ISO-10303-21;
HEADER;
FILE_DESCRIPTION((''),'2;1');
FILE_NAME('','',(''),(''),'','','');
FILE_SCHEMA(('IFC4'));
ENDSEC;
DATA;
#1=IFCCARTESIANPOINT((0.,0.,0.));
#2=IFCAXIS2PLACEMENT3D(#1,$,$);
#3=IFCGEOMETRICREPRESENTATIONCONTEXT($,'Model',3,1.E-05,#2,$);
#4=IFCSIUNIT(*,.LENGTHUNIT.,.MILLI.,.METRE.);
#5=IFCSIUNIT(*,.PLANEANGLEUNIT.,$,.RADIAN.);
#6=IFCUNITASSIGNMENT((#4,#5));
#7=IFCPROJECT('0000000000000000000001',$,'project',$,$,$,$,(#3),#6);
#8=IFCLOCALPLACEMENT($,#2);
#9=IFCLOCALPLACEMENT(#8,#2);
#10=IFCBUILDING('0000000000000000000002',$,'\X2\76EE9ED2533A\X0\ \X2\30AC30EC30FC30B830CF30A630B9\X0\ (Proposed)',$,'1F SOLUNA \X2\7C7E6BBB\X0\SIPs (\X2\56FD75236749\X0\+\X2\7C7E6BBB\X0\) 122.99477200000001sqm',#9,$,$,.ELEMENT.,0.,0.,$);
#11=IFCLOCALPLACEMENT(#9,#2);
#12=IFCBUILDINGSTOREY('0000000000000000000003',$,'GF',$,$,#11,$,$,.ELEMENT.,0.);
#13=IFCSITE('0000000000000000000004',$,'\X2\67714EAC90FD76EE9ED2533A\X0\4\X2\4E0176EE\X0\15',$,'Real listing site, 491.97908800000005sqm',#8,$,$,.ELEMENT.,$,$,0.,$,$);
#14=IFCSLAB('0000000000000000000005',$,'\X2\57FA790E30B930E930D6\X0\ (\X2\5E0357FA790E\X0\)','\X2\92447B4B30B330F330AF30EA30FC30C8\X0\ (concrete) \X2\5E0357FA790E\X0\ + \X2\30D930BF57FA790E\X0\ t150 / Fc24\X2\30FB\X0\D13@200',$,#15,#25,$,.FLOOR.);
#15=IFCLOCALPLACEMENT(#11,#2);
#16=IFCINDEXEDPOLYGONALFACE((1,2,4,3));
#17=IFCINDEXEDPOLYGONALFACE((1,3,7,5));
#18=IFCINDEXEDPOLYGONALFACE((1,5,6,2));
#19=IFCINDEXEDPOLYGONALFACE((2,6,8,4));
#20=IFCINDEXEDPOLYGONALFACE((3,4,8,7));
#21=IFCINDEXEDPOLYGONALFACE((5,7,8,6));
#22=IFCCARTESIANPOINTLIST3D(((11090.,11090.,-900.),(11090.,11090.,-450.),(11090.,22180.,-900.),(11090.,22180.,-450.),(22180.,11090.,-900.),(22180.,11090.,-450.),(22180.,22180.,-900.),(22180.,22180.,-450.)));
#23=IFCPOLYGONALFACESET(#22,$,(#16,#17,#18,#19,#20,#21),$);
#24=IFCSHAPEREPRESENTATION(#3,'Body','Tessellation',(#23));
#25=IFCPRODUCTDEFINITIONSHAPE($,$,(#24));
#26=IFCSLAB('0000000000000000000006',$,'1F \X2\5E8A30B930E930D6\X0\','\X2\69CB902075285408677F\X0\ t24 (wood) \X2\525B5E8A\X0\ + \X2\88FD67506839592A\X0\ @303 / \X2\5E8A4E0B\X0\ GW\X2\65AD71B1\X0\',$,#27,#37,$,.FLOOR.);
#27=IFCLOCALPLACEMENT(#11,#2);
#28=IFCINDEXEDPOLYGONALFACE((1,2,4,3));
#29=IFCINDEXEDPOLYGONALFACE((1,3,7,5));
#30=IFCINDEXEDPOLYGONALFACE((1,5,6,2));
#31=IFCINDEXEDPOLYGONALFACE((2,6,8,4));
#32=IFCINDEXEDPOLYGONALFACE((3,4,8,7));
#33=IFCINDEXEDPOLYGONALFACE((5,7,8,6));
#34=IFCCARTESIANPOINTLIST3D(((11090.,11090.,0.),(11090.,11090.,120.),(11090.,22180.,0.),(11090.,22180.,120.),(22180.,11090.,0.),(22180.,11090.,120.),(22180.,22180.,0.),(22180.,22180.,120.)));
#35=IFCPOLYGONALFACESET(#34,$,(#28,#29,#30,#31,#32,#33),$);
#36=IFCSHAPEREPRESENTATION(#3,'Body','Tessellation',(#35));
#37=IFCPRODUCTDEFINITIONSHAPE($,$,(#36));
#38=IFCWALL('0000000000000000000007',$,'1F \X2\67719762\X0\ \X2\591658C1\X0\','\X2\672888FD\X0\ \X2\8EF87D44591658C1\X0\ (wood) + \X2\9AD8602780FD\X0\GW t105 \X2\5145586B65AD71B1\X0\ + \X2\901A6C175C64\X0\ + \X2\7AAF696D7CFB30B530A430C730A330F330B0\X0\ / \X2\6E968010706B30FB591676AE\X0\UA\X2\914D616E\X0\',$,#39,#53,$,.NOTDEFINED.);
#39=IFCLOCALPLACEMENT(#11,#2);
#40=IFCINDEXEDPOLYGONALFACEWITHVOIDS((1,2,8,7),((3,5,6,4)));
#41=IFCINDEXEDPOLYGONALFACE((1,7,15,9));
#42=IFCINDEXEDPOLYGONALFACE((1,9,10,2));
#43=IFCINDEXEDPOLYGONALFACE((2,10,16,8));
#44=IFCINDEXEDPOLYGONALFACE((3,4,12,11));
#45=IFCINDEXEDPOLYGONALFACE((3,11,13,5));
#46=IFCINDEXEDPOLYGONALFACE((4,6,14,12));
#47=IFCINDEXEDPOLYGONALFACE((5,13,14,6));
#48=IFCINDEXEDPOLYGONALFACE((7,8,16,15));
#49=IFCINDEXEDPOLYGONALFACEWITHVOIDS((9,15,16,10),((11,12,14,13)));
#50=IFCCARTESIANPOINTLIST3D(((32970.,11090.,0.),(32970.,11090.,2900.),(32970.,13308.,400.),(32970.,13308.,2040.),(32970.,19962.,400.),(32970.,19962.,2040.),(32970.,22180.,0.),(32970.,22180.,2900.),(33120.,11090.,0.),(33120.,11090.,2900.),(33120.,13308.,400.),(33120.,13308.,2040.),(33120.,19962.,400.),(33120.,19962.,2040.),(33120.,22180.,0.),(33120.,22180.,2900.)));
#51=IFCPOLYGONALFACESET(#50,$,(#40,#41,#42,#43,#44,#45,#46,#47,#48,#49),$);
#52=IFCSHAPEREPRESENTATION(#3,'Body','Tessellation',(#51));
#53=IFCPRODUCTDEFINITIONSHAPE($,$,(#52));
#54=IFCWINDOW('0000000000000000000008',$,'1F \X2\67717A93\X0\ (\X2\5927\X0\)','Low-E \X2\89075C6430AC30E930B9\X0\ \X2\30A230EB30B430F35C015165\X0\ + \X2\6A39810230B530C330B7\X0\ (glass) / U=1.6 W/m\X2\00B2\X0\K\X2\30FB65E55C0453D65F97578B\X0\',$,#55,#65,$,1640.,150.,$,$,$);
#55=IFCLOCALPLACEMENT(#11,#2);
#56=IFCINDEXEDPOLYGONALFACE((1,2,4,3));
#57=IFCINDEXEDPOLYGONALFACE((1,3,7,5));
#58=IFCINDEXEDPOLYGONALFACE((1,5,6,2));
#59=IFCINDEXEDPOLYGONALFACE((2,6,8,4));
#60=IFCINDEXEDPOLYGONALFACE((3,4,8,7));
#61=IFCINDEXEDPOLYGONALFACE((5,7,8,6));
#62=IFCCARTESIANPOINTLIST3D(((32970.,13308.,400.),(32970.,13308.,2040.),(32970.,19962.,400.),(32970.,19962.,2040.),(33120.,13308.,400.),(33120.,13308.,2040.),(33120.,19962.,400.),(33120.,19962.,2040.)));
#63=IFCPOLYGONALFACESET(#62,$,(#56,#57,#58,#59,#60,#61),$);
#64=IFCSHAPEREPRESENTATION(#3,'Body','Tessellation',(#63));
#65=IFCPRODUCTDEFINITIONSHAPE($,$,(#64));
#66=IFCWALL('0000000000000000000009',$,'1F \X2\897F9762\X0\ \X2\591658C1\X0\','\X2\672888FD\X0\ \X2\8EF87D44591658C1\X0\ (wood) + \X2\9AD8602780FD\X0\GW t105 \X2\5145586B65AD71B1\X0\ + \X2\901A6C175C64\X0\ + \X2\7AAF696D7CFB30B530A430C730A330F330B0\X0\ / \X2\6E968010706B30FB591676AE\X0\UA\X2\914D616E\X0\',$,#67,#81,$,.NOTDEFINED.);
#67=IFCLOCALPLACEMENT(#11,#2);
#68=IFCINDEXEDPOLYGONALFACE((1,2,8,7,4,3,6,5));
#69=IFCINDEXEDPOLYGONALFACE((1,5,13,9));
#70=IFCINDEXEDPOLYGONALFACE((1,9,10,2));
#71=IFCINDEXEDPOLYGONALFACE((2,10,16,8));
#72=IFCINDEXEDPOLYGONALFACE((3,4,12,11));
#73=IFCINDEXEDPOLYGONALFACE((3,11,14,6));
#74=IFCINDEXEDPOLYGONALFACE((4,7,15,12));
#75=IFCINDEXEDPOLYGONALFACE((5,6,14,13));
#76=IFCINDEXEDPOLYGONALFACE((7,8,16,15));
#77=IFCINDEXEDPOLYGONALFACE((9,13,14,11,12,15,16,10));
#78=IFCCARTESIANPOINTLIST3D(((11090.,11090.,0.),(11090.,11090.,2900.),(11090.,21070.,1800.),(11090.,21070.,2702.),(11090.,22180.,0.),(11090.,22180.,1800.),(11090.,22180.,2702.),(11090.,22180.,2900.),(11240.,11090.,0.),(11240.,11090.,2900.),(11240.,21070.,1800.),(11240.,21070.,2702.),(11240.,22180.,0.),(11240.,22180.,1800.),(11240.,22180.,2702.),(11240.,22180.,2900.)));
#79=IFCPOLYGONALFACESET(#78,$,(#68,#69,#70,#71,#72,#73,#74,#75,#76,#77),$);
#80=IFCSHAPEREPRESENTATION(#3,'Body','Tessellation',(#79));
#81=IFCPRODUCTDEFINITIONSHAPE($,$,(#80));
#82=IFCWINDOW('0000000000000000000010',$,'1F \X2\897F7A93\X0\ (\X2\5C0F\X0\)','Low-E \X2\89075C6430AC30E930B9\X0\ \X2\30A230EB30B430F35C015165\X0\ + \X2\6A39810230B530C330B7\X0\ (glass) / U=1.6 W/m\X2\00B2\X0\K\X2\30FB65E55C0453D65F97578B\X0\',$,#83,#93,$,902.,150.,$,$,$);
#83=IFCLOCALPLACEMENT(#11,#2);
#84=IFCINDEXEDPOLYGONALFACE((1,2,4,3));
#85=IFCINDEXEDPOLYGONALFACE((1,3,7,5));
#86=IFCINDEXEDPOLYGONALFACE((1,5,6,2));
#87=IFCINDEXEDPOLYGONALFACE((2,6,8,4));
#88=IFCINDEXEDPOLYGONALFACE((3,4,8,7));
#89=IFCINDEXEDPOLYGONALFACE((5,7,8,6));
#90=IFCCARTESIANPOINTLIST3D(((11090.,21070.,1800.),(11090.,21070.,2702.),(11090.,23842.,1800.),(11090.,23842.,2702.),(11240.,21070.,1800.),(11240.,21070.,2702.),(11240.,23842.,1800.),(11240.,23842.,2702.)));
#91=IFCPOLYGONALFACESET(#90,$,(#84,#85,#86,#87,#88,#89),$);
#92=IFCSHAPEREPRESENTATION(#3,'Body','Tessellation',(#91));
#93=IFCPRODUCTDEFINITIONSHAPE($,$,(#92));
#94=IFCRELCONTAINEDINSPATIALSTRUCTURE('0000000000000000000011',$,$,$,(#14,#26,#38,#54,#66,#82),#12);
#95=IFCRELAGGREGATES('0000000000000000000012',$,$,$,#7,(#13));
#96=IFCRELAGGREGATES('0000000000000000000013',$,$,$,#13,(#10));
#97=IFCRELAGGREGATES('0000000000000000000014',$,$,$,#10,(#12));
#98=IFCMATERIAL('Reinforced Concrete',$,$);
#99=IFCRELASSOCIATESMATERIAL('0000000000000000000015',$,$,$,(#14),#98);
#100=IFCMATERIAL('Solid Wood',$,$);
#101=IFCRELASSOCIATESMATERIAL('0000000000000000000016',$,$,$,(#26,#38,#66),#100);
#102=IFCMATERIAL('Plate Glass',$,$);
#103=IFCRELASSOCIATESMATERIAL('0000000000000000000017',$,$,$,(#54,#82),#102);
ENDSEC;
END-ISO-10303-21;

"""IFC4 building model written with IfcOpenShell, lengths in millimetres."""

from ifc_helpers import new_model, si_unit, frame, frame_2d, origin, place, context, project, spatial, rectangle, extrude, material, element, fill, save


model = new_model("IFC4")

# Units and contexts
model_context = context("Model", 3, precision=1e-05, world=origin())
ifc_project = project(units=[si_unit("LENGTHUNIT", "METRE", prefix="MILLI"), si_unit("PLANEANGLEUNIT", "RADIAN")], contexts=[model_context])

# Site, building, storey
site_placement = place(None, origin())
site = spatial("IfcSite", under=ifc_project, at=site_placement, Name="東京都目黒区4丁目15", ObjectType="Real listing site, 491.97908800000005sqm", CompositionType="ELEMENT", RefElevation=0.0)
building_placement = place(site_placement, origin())
building = spatial("IfcBuilding", under=site, at=building_placement, Name="目黒区 ガレージハウス (Proposed)", ObjectType="1F SOLUNA 籾殻SIPs (国産杉+籾殻) 122.99477200000001sqm", CompositionType="ELEMENT", ElevationOfRefHeight=0.0, ElevationOfTerrain=0.0)
storey_placement = place(building_placement, origin())
storey = spatial("IfcBuildingStorey", under=building, at=storey_placement, Name="GF", CompositionType="ELEMENT", Elevation=0.0)

# Slabs
ifc_material_1 = material(Name="Reinforced Concrete")
slab_1_placement = place(storey_placement, frame((5545.0, 5545.0, -450.0)))
element("IfcSlab", 1, at=slab_1_placement, inside=storey, material=ifc_material_1, Name="基礎スラブ (布基礎)", Description="鉄筋コンクリート (concrete) 布基礎 + ベタ基礎 t150 / Fc24・D13@200", PredefinedType="FLOOR", context=model_context, shape_type="SweptSolid", body=[
    extrude(rectangle(XDim=11090.0, YDim=11090.0, at=frame_2d((5545.0, 5545.0))), frame((5545.0, 5545.0, -450.0)), (0.0, 0.0, 1.0), 450.0),
])
ifc_material_2 = material(Name="Solid Wood")
slab_2_placement = place(storey_placement, frame((5545.0, 5545.0, 0.0)))
element("IfcSlab", 2, at=slab_2_placement, inside=storey, material=ifc_material_2, Name="1F 床スラブ", Description="構造用合板 t24 (wood) 剛床 + 製材根太 @303 / 床下 GW断熱", PredefinedType="FLOOR", context=model_context, shape_type="SweptSolid", body=[
    extrude(rectangle(XDim=11090.0, YDim=11090.0, at=frame_2d((5545.0, 5545.0))), frame((5545.0, 5545.0, 0.0)), (0.0, 0.0, 1.0), 120.0),
])

# Shared definitions
ifc_material_3 = material(Name="Plate Glass")

# Walls, openings, windows
wall_1_placement = place(storey_placement, frame((16485.0, 5545.0, 0.0)))
wall_1 = element("IfcWall", 3, at=wall_1_placement, inside=storey, material=ifc_material_2, Name="1F 東面 外壁", Description="木製 軸組外壁 (wood) + 高性能GW t105 充填断熱 + 通気層 + 窯業系サイディング / 準耐火・外皮UA配慮", PredefinedType="NOTDEFINED", context=model_context, shape_type="SweptSolid", body=[
    extrude(rectangle(XDim=150.0, YDim=11090.0, at=frame_2d((75.0, 5545.0))), frame((16485.0, 5545.0, 0.0)), (0.0, 0.0, 1.0), 2900.0),
])
opening_1_placement = place(storey_placement, frame((16485.0, 6654.0, 200.0)))
opening_1 = element("IfcOpeningElement", 4, at=opening_1_placement, cuts=wall_1, PredefinedType="NOTDEFINED", context=model_context, shape_type="SweptSolid", body=[
    extrude(rectangle(XDim=150.0, YDim=6654.0, at=frame_2d((75.0, 3327.0))), frame((16485.0, 6654.0, 200.0)), (0.0, 0.0, 1.0), 1640.0),
])
window_1_placement = place(storey_placement, frame((16485.0, 6654.0, 200.0)))
window_1 = element("IfcWindow", 5, at=window_1_placement, inside=storey, material=ifc_material_3, Name="1F 東窓 (大)", Description="Low-E 複層ガラス アルゴン封入 + 樹脂サッシ (glass) / U=1.6 W/m²K・日射取得型", OverallHeight=1640.0, OverallWidth=150.0, context=model_context, shape_type="SweptSolid", body=[
    extrude(rectangle(XDim=150.0, YDim=6654.0, at=frame_2d((75.0, 3327.0))), frame((16485.0, 6654.0, 200.0)), (0.0, 0.0, 1.0), 1640.0),
])
fill(opening_1, window_1)
wall_2_placement = place(storey_placement, frame((5545.0, 5545.0, 0.0)))
wall_2 = element("IfcWall", 6, at=wall_2_placement, inside=storey, material=ifc_material_2, Name="1F 西面 外壁", Description="木製 軸組外壁 (wood) + 高性能GW t105 充填断熱 + 通気層 + 窯業系サイディング / 準耐火・外皮UA配慮", PredefinedType="NOTDEFINED", context=model_context, shape_type="SweptSolid", body=[
    extrude(rectangle(XDim=150.0, YDim=11090.0, at=frame_2d((75.0, 5545.0))), frame((5545.0, 5545.0, 0.0)), (0.0, 0.0, 1.0), 2900.0),
])
opening_2_placement = place(storey_placement, frame((5545.0, 10535.0, 900.0)))
opening_2 = element("IfcOpeningElement", 7, at=opening_2_placement, cuts=wall_2, PredefinedType="NOTDEFINED", context=model_context, shape_type="SweptSolid", body=[
    extrude(rectangle(XDim=150.0, YDim=2772.0, at=frame_2d((75.0, 1386.0))), frame((5545.0, 10535.0, 900.0)), (0.0, 0.0, 1.0), 902.0),
])
window_2_placement = place(storey_placement, frame((5545.0, 10535.0, 900.0)))
window_2 = element("IfcWindow", 8, at=window_2_placement, inside=storey, material=ifc_material_3, Name="1F 西窓 (小)", Description="Low-E 複層ガラス アルゴン封入 + 樹脂サッシ (glass) / U=1.6 W/m²K・日射取得型", OverallHeight=902.0, OverallWidth=150.0, context=model_context, shape_type="SweptSolid", body=[
    extrude(rectangle(XDim=150.0, YDim=2772.0, at=frame_2d((75.0, 1386.0))), frame((5545.0, 10535.0, 900.0)), (0.0, 0.0, 1.0), 902.0),
])
fill(opening_2, window_2)

save(model, "model.ifc")
